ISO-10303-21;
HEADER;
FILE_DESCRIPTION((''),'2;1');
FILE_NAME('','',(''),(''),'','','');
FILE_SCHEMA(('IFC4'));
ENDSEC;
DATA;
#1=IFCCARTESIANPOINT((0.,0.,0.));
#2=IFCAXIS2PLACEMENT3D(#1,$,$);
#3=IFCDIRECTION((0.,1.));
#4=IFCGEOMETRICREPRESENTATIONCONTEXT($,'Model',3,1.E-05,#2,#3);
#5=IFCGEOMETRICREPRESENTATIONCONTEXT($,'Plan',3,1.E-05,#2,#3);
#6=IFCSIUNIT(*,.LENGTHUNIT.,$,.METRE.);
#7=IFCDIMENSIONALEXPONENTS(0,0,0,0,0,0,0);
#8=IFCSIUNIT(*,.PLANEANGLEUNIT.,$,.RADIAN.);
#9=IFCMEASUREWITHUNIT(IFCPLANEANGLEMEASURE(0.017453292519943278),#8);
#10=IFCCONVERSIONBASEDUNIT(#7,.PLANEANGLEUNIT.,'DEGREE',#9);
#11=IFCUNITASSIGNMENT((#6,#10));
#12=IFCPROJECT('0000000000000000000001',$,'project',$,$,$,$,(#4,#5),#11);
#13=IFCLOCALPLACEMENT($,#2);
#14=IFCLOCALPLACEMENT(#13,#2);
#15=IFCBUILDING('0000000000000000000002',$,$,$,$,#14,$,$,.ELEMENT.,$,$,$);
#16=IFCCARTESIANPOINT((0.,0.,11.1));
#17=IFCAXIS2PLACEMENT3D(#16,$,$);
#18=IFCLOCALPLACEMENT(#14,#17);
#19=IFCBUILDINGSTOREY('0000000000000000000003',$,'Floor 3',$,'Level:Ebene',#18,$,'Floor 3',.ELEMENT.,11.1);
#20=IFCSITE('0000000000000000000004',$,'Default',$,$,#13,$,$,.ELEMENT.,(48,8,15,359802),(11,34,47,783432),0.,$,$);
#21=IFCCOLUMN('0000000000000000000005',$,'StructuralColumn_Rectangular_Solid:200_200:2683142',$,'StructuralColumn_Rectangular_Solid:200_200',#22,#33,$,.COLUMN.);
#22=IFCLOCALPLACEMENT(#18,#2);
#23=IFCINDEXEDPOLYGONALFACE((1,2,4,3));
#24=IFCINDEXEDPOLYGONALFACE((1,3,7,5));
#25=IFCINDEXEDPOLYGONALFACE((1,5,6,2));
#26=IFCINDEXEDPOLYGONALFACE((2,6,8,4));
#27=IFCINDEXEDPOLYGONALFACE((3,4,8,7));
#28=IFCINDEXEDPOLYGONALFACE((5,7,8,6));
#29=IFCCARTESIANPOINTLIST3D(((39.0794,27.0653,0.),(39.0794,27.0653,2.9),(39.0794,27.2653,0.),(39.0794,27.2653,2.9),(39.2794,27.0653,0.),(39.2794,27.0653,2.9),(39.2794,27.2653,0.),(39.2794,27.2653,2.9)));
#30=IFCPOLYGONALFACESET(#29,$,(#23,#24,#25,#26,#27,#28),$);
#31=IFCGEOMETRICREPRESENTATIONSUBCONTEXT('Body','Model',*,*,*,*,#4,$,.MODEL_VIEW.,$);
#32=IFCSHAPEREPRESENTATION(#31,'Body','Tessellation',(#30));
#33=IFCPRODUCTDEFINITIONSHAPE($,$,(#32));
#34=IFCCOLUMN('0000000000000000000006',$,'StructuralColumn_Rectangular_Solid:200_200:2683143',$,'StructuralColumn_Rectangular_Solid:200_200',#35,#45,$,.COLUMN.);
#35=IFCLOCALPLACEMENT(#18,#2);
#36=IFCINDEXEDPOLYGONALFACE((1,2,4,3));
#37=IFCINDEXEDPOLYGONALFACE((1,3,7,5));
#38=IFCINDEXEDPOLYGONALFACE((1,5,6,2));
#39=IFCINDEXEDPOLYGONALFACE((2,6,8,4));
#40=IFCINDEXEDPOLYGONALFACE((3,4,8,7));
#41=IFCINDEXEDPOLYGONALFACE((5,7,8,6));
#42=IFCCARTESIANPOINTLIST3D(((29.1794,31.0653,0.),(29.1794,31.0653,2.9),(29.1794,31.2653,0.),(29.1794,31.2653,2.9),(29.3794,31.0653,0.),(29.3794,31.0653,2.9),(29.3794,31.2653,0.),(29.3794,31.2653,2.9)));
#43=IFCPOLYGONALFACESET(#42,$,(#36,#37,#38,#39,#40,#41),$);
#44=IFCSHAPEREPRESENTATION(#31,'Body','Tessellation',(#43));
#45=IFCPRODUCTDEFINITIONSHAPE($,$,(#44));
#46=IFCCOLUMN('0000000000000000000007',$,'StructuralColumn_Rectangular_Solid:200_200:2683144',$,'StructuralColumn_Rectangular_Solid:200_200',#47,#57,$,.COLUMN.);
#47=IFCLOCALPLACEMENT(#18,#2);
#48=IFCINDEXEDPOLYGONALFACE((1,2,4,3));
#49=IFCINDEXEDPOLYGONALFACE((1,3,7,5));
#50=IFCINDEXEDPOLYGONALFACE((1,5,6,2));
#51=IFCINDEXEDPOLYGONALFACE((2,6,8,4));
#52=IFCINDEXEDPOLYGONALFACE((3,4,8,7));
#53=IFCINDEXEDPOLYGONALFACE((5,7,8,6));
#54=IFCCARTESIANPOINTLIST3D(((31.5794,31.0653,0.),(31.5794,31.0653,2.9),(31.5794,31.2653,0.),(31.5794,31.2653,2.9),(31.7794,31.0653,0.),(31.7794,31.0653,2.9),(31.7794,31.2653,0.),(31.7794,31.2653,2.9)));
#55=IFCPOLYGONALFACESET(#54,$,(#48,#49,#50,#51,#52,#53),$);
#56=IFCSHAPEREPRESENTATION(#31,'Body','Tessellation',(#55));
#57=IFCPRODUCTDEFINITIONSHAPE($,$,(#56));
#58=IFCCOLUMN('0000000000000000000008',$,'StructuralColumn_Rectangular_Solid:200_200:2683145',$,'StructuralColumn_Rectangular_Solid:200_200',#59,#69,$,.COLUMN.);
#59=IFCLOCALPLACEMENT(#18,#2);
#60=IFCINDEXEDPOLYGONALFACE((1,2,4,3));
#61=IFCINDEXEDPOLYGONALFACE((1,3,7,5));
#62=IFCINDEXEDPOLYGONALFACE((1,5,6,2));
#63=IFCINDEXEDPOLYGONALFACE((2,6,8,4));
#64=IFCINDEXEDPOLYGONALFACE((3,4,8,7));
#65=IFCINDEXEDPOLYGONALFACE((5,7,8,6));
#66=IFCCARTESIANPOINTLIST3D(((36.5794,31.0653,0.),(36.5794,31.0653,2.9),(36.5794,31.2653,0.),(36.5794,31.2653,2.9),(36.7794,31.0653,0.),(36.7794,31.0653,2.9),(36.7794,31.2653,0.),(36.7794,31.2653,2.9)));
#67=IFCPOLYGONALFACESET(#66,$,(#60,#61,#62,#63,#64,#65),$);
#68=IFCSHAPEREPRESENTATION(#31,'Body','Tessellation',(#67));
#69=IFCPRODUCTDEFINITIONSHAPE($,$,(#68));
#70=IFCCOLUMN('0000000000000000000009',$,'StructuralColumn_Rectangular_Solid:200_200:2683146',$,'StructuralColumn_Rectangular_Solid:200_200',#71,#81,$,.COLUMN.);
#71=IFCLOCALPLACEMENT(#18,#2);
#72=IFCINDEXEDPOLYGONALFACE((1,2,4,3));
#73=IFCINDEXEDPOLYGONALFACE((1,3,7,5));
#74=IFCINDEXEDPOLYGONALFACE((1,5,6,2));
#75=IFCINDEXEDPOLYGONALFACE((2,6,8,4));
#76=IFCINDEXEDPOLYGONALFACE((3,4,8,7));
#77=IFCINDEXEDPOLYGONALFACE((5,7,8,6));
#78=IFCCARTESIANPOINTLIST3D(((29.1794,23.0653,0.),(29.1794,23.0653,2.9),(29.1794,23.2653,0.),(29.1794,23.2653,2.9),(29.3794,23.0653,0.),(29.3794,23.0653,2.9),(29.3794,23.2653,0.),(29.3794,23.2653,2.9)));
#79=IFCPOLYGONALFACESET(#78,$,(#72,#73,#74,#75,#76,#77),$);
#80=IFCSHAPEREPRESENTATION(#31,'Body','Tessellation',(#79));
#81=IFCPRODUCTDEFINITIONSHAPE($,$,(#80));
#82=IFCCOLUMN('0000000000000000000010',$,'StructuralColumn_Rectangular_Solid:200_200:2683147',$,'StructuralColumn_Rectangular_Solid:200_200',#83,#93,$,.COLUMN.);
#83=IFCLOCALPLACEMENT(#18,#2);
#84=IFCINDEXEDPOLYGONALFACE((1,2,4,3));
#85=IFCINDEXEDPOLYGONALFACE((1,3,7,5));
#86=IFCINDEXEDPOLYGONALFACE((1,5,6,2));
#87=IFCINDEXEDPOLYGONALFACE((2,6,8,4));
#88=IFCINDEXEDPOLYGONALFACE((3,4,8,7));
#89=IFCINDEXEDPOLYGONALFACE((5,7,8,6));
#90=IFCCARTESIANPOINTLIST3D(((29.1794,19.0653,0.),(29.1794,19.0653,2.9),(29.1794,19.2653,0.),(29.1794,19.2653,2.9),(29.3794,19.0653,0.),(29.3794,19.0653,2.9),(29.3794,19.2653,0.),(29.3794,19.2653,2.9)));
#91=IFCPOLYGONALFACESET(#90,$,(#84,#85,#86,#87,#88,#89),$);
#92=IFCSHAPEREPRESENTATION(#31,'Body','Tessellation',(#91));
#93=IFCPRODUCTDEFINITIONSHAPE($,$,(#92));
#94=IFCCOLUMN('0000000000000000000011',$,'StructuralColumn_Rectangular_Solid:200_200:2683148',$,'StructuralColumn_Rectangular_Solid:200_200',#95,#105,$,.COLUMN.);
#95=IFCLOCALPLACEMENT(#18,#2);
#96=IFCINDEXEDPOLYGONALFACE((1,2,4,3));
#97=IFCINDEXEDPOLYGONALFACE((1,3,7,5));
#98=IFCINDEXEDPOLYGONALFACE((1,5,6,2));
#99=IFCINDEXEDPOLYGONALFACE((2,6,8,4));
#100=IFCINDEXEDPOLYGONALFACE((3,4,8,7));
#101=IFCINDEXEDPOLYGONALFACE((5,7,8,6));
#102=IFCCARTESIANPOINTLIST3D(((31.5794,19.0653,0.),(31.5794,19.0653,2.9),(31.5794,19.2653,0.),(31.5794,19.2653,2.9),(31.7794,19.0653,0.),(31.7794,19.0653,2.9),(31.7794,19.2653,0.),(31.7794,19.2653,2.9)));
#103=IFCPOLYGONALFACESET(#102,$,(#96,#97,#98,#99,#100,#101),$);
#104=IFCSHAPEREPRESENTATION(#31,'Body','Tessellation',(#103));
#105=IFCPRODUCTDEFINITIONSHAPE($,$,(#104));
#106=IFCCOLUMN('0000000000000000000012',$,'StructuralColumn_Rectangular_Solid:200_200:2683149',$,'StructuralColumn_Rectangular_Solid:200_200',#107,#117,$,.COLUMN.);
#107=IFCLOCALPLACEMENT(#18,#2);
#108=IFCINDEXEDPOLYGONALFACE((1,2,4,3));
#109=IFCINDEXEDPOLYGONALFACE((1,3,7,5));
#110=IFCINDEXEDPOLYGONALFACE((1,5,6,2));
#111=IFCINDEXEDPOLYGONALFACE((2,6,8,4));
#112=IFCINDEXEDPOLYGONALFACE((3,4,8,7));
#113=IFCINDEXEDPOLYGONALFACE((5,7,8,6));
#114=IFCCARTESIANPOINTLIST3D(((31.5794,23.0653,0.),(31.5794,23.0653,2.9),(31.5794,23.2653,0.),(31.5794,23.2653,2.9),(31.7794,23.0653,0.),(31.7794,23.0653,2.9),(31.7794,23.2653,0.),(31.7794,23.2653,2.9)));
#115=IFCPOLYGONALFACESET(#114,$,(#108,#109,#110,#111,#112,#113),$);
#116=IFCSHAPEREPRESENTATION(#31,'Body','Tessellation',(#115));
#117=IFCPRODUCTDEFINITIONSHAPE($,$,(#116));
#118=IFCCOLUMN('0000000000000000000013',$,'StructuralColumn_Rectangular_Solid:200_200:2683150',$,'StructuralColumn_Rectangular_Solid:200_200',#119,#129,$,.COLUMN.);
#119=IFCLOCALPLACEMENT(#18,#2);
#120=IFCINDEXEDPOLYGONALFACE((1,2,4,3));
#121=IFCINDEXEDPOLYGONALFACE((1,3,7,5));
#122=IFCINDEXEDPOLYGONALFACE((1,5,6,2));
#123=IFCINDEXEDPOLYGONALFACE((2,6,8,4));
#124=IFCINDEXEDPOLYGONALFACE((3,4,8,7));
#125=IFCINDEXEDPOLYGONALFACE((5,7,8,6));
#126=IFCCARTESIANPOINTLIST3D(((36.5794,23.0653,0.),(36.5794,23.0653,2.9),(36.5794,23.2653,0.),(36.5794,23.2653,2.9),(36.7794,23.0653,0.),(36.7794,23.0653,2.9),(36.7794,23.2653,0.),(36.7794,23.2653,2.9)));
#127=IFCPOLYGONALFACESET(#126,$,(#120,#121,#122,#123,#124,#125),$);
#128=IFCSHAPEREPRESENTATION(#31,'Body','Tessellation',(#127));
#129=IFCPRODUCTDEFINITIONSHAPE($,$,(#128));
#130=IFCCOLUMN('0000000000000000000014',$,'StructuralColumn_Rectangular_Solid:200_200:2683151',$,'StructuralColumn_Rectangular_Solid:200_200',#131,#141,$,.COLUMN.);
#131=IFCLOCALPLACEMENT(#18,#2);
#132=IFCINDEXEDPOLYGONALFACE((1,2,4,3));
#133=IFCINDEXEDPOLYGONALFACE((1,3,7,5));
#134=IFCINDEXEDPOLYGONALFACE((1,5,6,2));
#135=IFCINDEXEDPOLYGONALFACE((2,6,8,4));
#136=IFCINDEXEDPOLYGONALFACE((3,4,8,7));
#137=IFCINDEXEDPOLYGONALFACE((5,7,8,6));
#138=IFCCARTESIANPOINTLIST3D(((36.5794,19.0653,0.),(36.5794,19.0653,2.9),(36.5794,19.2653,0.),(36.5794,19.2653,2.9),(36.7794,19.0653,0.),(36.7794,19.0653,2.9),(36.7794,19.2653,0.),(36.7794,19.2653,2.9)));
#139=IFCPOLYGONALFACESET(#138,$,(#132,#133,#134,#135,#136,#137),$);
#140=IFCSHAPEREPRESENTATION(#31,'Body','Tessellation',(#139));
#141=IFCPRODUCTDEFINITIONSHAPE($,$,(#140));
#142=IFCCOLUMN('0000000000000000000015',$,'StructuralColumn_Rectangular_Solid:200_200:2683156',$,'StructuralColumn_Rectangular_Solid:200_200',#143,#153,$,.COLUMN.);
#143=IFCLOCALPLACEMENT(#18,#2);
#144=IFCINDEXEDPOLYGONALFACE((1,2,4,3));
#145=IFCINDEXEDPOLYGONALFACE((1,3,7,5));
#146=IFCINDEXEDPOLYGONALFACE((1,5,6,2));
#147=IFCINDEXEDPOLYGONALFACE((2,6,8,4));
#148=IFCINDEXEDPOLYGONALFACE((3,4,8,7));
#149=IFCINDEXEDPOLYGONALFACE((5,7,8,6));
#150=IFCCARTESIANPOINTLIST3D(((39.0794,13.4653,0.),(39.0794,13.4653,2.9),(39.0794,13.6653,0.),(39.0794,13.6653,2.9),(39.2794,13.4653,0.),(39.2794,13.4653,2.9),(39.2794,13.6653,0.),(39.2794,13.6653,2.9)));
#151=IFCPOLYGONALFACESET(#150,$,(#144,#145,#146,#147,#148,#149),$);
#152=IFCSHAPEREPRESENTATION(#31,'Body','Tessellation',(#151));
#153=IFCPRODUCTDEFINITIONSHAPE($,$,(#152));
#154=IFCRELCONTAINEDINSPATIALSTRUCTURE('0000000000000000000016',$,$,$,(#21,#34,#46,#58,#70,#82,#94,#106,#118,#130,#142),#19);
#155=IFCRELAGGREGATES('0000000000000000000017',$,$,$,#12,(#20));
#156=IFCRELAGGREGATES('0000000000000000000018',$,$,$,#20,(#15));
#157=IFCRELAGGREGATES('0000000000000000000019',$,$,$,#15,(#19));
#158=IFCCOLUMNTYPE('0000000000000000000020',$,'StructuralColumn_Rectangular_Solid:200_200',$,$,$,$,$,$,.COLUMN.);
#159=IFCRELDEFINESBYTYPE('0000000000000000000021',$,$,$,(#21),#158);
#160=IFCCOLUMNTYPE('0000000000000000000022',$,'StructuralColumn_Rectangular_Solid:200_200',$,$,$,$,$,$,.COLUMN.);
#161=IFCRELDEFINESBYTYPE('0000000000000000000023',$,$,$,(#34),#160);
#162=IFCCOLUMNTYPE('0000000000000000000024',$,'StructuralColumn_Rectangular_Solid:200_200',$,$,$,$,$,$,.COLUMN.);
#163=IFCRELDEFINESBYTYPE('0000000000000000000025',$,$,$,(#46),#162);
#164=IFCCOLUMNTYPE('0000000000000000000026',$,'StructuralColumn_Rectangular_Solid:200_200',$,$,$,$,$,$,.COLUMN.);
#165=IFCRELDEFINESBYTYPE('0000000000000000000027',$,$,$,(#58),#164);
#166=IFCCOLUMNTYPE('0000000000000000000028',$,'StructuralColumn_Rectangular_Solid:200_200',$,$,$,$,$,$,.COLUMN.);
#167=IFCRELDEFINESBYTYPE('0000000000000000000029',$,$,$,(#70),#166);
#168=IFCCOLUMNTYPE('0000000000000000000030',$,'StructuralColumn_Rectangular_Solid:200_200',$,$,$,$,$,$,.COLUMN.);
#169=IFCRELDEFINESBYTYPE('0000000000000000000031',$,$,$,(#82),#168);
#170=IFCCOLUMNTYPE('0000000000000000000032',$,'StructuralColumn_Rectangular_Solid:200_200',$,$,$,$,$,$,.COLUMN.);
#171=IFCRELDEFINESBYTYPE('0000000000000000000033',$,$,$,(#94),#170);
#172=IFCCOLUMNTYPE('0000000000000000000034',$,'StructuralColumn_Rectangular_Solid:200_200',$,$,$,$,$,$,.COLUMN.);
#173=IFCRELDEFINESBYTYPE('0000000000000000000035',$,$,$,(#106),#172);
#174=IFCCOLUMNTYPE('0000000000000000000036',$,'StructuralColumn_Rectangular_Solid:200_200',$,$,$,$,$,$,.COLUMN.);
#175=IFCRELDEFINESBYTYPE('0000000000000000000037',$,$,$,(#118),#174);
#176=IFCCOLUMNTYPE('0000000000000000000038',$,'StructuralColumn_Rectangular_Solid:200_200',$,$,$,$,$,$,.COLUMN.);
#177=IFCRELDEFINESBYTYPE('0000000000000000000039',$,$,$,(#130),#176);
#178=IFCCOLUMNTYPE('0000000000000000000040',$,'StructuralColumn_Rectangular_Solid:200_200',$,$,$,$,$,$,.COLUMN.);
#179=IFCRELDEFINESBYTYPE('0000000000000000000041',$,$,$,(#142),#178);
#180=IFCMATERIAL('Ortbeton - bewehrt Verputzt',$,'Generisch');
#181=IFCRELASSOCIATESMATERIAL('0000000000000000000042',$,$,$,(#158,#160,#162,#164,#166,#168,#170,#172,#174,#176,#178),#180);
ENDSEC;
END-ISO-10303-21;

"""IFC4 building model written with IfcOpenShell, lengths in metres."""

from ifc_helpers import new_model, entity, si_unit, converted_unit, direction, frame, frame_2d, origin, origin_2d_with_axis, place, context, subcontext, project, spatial, rectangle, extrude, source, transform, mapped, material, material_profile, profile_set, type_object, type_shapes, element, save


model = new_model("IFC4")

# Units and contexts
model_context = context("Model", 3, precision=1e-05, world=origin(), true_north=direction((0.0, 1.0)))
plan_context = context("Plan", 3, precision=1e-05, world=origin(), true_north=direction((0.0, 1.0)))
body_context = subcontext(model_context, "Body", "Model", "MODEL_VIEW")
ifc_project = project(units=[si_unit("LENGTHUNIT", "METRE"), converted_unit("PLANEANGLEUNIT", "DEGREE", entity("IfcPlaneAngleMeasure", 0.017453292519943278), si_unit("PLANEANGLEUNIT", "RADIAN"), dimensions=[0, 0, 0, 0, 0, 0, 0])], contexts=[model_context, plan_context])

# Site, building, storey
site_placement = place(None, origin())
site = spatial("IfcSite", under=ifc_project, at=site_placement, Name="Default", CompositionType="ELEMENT", RefLatitude=(48, 8, 15, 359802), RefLongitude=(11, 34, 47, 783432), RefElevation=0.0)
building_placement = place(site_placement, origin())
building = spatial("IfcBuilding", under=site, at=building_placement, CompositionType="ELEMENT")
storey_placement = place(building_placement, frame((0.0, 0.0, 11.1)))
storey = spatial("IfcBuildingStorey", under=building, at=storey_placement, Name="Floor 3", ObjectType="Level:Ebene", LongName="Floor 3", CompositionType="ELEMENT", Elevation=11.1)

# Columns
ifc_material_1 = material(Name="Ortbeton - bewehrt Verputzt", Category="Generisch")
ifc_material_profile = material_profile(ifc_material_1, rectangle(XDim=0.2, YDim=0.2, at=frame_2d((0.0, 0.0), x_axis=(1.0, 0.0))), Name="200_200")
ifc_profile_set = profile_set([ifc_material_profile], Name="200_200")
column_type_1 = type_object("IfcColumnType", Name="StructuralColumn_Rectangular_Solid:200_200", PredefinedType="COLUMN", material=ifc_profile_set)
shared_shape_1 = source(origin(), body_context, "Body", "SweptSolid", [
    extrude(rectangle(XDim=0.2, YDim=0.2, at=frame_2d((0.0, 0.0), x_axis=(1.0, 0.0))), frame((39.1794, 27.1653, 11.1), z_axis=(0.0, 0.0, 1.0), x_axis=(-1.0, 0.0, 0.0)), (0.0, 0.0, 1.0), 2.9),
])
type_shapes(column_type_1, [shared_shape_1])
column_1_placement = place(storey_placement, frame((0.0, 0.0, -11.1)))
element("IfcColumn", 1, at=column_1_placement, inside=storey, type_object=column_type_1, Name="StructuralColumn_Rectangular_Solid:200_200:2683142", ObjectType="StructuralColumn_Rectangular_Solid:200_200", PredefinedType="COLUMN", context=body_context, shape_type="MappedRepresentation", body=[
    mapped(shared_shape_1, transform((0.0, 0.0, 0.0), scale=1.0)),
])
column_type_2 = type_object("IfcColumnType", Name="StructuralColumn_Rectangular_Solid:200_200", PredefinedType="COLUMN", material=ifc_profile_set)
shared_shape_2 = source(origin(), body_context, "Body", "SweptSolid", [
    extrude(rectangle(XDim=0.2, YDim=0.2, at=origin_2d_with_axis()), frame((29.2794, 31.1653, 11.1), z_axis=(0.0, 0.0, 1.0), x_axis=(-1.0, 0.0, 0.0)), (0.0, 0.0, 1.0), 2.9),
])
type_shapes(column_type_2, [shared_shape_2])
column_2_placement = place(storey_placement, frame((0.0, 0.0, -11.1)))
element("IfcColumn", 2, at=column_2_placement, inside=storey, type_object=column_type_2, Name="StructuralColumn_Rectangular_Solid:200_200:2683143", ObjectType="StructuralColumn_Rectangular_Solid:200_200", PredefinedType="COLUMN", context=body_context, shape_type="MappedRepresentation", body=[
    mapped(shared_shape_2, transform((0.0, 0.0, 0.0), scale=1.0)),
])
column_type_3 = type_object("IfcColumnType", Name="StructuralColumn_Rectangular_Solid:200_200", PredefinedType="COLUMN", material=ifc_profile_set)
shared_shape_3 = source(origin(), body_context, "Body", "SweptSolid", [
    extrude(rectangle(XDim=0.2, YDim=0.2, at=origin_2d_with_axis()), frame((31.6794, 31.1653, 11.1), z_axis=(0.0, 0.0, 1.0), x_axis=(-1.0, 0.0, 0.0)), (0.0, 0.0, 1.0), 2.9),
])
type_shapes(column_type_3, [shared_shape_3])
column_3_placement = place(storey_placement, frame((0.0, 0.0, -11.1)))
element("IfcColumn", 3, at=column_3_placement, inside=storey, type_object=column_type_3, Name="StructuralColumn_Rectangular_Solid:200_200:2683144", ObjectType="StructuralColumn_Rectangular_Solid:200_200", PredefinedType="COLUMN", context=body_context, shape_type="MappedRepresentation", body=[
    mapped(shared_shape_3, transform((0.0, 0.0, 0.0), scale=1.0)),
])
column_type_4 = type_object("IfcColumnType", Name="StructuralColumn_Rectangular_Solid:200_200", PredefinedType="COLUMN", material=ifc_profile_set)
shared_shape_4 = source(origin(), body_context, "Body", "SweptSolid", [
    extrude(rectangle(XDim=0.2, YDim=0.2, at=frame_2d((0.0, 0.0), x_axis=(1.0, 0.0))), frame((36.6794, 31.1653, 11.1), z_axis=(0.0, 0.0, 1.0), x_axis=(-1.0, 0.0, 0.0)), (0.0, 0.0, 1.0), 2.9),
])
type_shapes(column_type_4, [shared_shape_4])
column_4_placement = place(storey_placement, frame((0.0, 0.0, -11.1)))
element("IfcColumn", 4, at=column_4_placement, inside=storey, type_object=column_type_4, Name="StructuralColumn_Rectangular_Solid:200_200:2683145", ObjectType="StructuralColumn_Rectangular_Solid:200_200", PredefinedType="COLUMN", context=body_context, shape_type="MappedRepresentation", body=[
    mapped(shared_shape_4, transform((0.0, 0.0, 0.0), scale=1.0)),
])
column_type_5 = type_object("IfcColumnType", Name="StructuralColumn_Rectangular_Solid:200_200", PredefinedType="COLUMN", material=ifc_profile_set)
shared_shape_5 = source(origin(), body_context, "Body", "SweptSolid", [
    extrude(rectangle(XDim=0.2, YDim=0.2, at=origin_2d_with_axis()), frame((29.2794, 23.1653, 11.1), z_axis=(0.0, 0.0, 1.0), x_axis=(-1.0, 0.0, 0.0)), (0.0, 0.0, 1.0), 2.9),
])
type_shapes(column_type_5, [shared_shape_5])
column_5_placement = place(storey_placement, frame((0.0, 0.0, -11.1)))
element("IfcColumn", 5, at=column_5_placement, inside=storey, type_object=column_type_5, Name="StructuralColumn_Rectangular_Solid:200_200:2683146", ObjectType="StructuralColumn_Rectangular_Solid:200_200", PredefinedType="COLUMN", context=body_context, shape_type="MappedRepresentation", body=[
    mapped(shared_shape_5, transform((0.0, 0.0, 0.0), scale=1.0)),
])
column_type_6 = type_object("IfcColumnType", Name="StructuralColumn_Rectangular_Solid:200_200", PredefinedType="COLUMN", material=ifc_profile_set)
shared_shape_6 = source(origin(), body_context, "Body", "SweptSolid", [
    extrude(rectangle(XDim=0.2, YDim=0.2, at=frame_2d((0.0, 0.0), x_axis=(1.0, 0.0))), frame((29.2794, 19.1653, 11.1), z_axis=(0.0, 0.0, 1.0), x_axis=(-1.0, 0.0, 0.0)), (0.0, 0.0, 1.0), 2.9),
])
type_shapes(column_type_6, [shared_shape_6])
column_6_placement = place(storey_placement, frame((0.0, 0.0, -11.1)))
element("IfcColumn", 6, at=column_6_placement, inside=storey, type_object=column_type_6, Name="StructuralColumn_Rectangular_Solid:200_200:2683147", ObjectType="StructuralColumn_Rectangular_Solid:200_200", PredefinedType="COLUMN", context=body_context, shape_type="MappedRepresentation", body=[
    mapped(shared_shape_6, transform((0.0, 0.0, 0.0), scale=1.0)),
])
column_type_7 = type_object("IfcColumnType", Name="StructuralColumn_Rectangular_Solid:200_200", PredefinedType="COLUMN", material=ifc_profile_set)
shared_shape_7 = source(origin(), body_context, "Body", "SweptSolid", [
    extrude(rectangle(XDim=0.2, YDim=0.2, at=frame_2d((0.0, 0.0), x_axis=(1.0, 0.0))), frame((31.6794, 19.1653, 11.1), z_axis=(0.0, 0.0, 1.0), x_axis=(-1.0, 0.0, 0.0)), (0.0, 0.0, 1.0), 2.9),
])
type_shapes(column_type_7, [shared_shape_7])
column_7_placement = place(storey_placement, frame((0.0, 0.0, -11.1)))
element("IfcColumn", 7, at=column_7_placement, inside=storey, type_object=column_type_7, Name="StructuralColumn_Rectangular_Solid:200_200:2683148", ObjectType="StructuralColumn_Rectangular_Solid:200_200", PredefinedType="COLUMN", context=body_context, shape_type="MappedRepresentation", body=[
    mapped(shared_shape_7, transform((0.0, 0.0, 0.0), scale=1.0)),
])
column_type_8 = type_object("IfcColumnType", Name="StructuralColumn_Rectangular_Solid:200_200", PredefinedType="COLUMN", material=ifc_profile_set)
shared_shape_8 = source(origin(), body_context, "Body", "SweptSolid", [
    extrude(rectangle(XDim=0.2, YDim=0.2, at=origin_2d_with_axis()), frame((31.6794, 23.1653, 11.1), z_axis=(0.0, 0.0, 1.0), x_axis=(-1.0, 0.0, 0.0)), (0.0, 0.0, 1.0), 2.9),
])
type_shapes(column_type_8, [shared_shape_8])
column_8_placement = place(storey_placement, frame((0.0, 0.0, -11.1)))
element("IfcColumn", 8, at=column_8_placement, inside=storey, type_object=column_type_8, Name="StructuralColumn_Rectangular_Solid:200_200:2683149", ObjectType="StructuralColumn_Rectangular_Solid:200_200", PredefinedType="COLUMN", context=body_context, shape_type="MappedRepresentation", body=[
    mapped(shared_shape_8, transform((0.0, 0.0, 0.0), scale=1.0)),
])
column_type_9 = type_object("IfcColumnType", Name="StructuralColumn_Rectangular_Solid:200_200", PredefinedType="COLUMN", material=ifc_profile_set)
shared_shape_9 = source(origin(), body_context, "Body", "SweptSolid", [
    extrude(rectangle(XDim=0.2, YDim=0.2, at=origin_2d_with_axis()), frame((36.6794, 23.1653, 11.1), z_axis=(0.0, 0.0, 1.0), x_axis=(-1.0, 0.0, 0.0)), (0.0, 0.0, 1.0), 2.9),
])
type_shapes(column_type_9, [shared_shape_9])
column_9_placement = place(storey_placement, frame((0.0, 0.0, -11.1)))
element("IfcColumn", 9, at=column_9_placement, inside=storey, type_object=column_type_9, Name="StructuralColumn_Rectangular_Solid:200_200:2683150", ObjectType="StructuralColumn_Rectangular_Solid:200_200", PredefinedType="COLUMN", context=body_context, shape_type="MappedRepresentation", body=[
    mapped(shared_shape_9, transform((0.0, 0.0, 0.0), scale=1.0)),
])
column_type_10 = type_object("IfcColumnType", Name="StructuralColumn_Rectangular_Solid:200_200", PredefinedType="COLUMN", material=ifc_profile_set)
shared_shape_10 = source(origin(), body_context, "Body", "SweptSolid", [
    extrude(rectangle(XDim=0.2, YDim=0.2, at=frame_2d((0.0, 0.0), x_axis=(1.0, 0.0))), frame((36.6794, 19.1653, 11.1), z_axis=(0.0, 0.0, 1.0), x_axis=(-1.0, 0.0, 0.0)), (0.0, 0.0, 1.0), 2.9),
])
type_shapes(column_type_10, [shared_shape_10])
column_10_placement = place(storey_placement, frame((0.0, 0.0, -11.1)))
element("IfcColumn", 10, at=column_10_placement, inside=storey, type_object=column_type_10, Name="StructuralColumn_Rectangular_Solid:200_200:2683151", ObjectType="StructuralColumn_Rectangular_Solid:200_200", PredefinedType="COLUMN", context=body_context, shape_type="MappedRepresentation", body=[
    mapped(shared_shape_10, transform((0.0, 0.0, 0.0), scale=1.0)),
])
column_type_11 = type_object("IfcColumnType", Name="StructuralColumn_Rectangular_Solid:200_200", PredefinedType="COLUMN", material=ifc_profile_set)
shared_shape_11 = source(origin(), body_context, "Body", "SweptSolid", [
    extrude(rectangle(XDim=0.2, YDim=0.2, at=frame_2d((0.0, 0.0), x_axis=(1.0, 0.0))), frame((39.1794, 13.5653, 11.1), z_axis=(0.0, 0.0, 1.0), x_axis=(-1.0, 0.0, 0.0)), (0.0, 0.0, 1.0), 2.9),
])
type_shapes(column_type_11, [shared_shape_11])
column_11_placement = place(storey_placement, frame((0.0, 0.0, -11.1)))
element("IfcColumn", 11, at=column_11_placement, inside=storey, type_object=column_type_11, Name="StructuralColumn_Rectangular_Solid:200_200:2683156", ObjectType="StructuralColumn_Rectangular_Solid:200_200", PredefinedType="COLUMN", context=body_context, shape_type="MappedRepresentation", body=[
    mapped(shared_shape_11, transform((0.0, 0.0, 0.0), scale=1.0)),
])

save(model, "model.ifc")
